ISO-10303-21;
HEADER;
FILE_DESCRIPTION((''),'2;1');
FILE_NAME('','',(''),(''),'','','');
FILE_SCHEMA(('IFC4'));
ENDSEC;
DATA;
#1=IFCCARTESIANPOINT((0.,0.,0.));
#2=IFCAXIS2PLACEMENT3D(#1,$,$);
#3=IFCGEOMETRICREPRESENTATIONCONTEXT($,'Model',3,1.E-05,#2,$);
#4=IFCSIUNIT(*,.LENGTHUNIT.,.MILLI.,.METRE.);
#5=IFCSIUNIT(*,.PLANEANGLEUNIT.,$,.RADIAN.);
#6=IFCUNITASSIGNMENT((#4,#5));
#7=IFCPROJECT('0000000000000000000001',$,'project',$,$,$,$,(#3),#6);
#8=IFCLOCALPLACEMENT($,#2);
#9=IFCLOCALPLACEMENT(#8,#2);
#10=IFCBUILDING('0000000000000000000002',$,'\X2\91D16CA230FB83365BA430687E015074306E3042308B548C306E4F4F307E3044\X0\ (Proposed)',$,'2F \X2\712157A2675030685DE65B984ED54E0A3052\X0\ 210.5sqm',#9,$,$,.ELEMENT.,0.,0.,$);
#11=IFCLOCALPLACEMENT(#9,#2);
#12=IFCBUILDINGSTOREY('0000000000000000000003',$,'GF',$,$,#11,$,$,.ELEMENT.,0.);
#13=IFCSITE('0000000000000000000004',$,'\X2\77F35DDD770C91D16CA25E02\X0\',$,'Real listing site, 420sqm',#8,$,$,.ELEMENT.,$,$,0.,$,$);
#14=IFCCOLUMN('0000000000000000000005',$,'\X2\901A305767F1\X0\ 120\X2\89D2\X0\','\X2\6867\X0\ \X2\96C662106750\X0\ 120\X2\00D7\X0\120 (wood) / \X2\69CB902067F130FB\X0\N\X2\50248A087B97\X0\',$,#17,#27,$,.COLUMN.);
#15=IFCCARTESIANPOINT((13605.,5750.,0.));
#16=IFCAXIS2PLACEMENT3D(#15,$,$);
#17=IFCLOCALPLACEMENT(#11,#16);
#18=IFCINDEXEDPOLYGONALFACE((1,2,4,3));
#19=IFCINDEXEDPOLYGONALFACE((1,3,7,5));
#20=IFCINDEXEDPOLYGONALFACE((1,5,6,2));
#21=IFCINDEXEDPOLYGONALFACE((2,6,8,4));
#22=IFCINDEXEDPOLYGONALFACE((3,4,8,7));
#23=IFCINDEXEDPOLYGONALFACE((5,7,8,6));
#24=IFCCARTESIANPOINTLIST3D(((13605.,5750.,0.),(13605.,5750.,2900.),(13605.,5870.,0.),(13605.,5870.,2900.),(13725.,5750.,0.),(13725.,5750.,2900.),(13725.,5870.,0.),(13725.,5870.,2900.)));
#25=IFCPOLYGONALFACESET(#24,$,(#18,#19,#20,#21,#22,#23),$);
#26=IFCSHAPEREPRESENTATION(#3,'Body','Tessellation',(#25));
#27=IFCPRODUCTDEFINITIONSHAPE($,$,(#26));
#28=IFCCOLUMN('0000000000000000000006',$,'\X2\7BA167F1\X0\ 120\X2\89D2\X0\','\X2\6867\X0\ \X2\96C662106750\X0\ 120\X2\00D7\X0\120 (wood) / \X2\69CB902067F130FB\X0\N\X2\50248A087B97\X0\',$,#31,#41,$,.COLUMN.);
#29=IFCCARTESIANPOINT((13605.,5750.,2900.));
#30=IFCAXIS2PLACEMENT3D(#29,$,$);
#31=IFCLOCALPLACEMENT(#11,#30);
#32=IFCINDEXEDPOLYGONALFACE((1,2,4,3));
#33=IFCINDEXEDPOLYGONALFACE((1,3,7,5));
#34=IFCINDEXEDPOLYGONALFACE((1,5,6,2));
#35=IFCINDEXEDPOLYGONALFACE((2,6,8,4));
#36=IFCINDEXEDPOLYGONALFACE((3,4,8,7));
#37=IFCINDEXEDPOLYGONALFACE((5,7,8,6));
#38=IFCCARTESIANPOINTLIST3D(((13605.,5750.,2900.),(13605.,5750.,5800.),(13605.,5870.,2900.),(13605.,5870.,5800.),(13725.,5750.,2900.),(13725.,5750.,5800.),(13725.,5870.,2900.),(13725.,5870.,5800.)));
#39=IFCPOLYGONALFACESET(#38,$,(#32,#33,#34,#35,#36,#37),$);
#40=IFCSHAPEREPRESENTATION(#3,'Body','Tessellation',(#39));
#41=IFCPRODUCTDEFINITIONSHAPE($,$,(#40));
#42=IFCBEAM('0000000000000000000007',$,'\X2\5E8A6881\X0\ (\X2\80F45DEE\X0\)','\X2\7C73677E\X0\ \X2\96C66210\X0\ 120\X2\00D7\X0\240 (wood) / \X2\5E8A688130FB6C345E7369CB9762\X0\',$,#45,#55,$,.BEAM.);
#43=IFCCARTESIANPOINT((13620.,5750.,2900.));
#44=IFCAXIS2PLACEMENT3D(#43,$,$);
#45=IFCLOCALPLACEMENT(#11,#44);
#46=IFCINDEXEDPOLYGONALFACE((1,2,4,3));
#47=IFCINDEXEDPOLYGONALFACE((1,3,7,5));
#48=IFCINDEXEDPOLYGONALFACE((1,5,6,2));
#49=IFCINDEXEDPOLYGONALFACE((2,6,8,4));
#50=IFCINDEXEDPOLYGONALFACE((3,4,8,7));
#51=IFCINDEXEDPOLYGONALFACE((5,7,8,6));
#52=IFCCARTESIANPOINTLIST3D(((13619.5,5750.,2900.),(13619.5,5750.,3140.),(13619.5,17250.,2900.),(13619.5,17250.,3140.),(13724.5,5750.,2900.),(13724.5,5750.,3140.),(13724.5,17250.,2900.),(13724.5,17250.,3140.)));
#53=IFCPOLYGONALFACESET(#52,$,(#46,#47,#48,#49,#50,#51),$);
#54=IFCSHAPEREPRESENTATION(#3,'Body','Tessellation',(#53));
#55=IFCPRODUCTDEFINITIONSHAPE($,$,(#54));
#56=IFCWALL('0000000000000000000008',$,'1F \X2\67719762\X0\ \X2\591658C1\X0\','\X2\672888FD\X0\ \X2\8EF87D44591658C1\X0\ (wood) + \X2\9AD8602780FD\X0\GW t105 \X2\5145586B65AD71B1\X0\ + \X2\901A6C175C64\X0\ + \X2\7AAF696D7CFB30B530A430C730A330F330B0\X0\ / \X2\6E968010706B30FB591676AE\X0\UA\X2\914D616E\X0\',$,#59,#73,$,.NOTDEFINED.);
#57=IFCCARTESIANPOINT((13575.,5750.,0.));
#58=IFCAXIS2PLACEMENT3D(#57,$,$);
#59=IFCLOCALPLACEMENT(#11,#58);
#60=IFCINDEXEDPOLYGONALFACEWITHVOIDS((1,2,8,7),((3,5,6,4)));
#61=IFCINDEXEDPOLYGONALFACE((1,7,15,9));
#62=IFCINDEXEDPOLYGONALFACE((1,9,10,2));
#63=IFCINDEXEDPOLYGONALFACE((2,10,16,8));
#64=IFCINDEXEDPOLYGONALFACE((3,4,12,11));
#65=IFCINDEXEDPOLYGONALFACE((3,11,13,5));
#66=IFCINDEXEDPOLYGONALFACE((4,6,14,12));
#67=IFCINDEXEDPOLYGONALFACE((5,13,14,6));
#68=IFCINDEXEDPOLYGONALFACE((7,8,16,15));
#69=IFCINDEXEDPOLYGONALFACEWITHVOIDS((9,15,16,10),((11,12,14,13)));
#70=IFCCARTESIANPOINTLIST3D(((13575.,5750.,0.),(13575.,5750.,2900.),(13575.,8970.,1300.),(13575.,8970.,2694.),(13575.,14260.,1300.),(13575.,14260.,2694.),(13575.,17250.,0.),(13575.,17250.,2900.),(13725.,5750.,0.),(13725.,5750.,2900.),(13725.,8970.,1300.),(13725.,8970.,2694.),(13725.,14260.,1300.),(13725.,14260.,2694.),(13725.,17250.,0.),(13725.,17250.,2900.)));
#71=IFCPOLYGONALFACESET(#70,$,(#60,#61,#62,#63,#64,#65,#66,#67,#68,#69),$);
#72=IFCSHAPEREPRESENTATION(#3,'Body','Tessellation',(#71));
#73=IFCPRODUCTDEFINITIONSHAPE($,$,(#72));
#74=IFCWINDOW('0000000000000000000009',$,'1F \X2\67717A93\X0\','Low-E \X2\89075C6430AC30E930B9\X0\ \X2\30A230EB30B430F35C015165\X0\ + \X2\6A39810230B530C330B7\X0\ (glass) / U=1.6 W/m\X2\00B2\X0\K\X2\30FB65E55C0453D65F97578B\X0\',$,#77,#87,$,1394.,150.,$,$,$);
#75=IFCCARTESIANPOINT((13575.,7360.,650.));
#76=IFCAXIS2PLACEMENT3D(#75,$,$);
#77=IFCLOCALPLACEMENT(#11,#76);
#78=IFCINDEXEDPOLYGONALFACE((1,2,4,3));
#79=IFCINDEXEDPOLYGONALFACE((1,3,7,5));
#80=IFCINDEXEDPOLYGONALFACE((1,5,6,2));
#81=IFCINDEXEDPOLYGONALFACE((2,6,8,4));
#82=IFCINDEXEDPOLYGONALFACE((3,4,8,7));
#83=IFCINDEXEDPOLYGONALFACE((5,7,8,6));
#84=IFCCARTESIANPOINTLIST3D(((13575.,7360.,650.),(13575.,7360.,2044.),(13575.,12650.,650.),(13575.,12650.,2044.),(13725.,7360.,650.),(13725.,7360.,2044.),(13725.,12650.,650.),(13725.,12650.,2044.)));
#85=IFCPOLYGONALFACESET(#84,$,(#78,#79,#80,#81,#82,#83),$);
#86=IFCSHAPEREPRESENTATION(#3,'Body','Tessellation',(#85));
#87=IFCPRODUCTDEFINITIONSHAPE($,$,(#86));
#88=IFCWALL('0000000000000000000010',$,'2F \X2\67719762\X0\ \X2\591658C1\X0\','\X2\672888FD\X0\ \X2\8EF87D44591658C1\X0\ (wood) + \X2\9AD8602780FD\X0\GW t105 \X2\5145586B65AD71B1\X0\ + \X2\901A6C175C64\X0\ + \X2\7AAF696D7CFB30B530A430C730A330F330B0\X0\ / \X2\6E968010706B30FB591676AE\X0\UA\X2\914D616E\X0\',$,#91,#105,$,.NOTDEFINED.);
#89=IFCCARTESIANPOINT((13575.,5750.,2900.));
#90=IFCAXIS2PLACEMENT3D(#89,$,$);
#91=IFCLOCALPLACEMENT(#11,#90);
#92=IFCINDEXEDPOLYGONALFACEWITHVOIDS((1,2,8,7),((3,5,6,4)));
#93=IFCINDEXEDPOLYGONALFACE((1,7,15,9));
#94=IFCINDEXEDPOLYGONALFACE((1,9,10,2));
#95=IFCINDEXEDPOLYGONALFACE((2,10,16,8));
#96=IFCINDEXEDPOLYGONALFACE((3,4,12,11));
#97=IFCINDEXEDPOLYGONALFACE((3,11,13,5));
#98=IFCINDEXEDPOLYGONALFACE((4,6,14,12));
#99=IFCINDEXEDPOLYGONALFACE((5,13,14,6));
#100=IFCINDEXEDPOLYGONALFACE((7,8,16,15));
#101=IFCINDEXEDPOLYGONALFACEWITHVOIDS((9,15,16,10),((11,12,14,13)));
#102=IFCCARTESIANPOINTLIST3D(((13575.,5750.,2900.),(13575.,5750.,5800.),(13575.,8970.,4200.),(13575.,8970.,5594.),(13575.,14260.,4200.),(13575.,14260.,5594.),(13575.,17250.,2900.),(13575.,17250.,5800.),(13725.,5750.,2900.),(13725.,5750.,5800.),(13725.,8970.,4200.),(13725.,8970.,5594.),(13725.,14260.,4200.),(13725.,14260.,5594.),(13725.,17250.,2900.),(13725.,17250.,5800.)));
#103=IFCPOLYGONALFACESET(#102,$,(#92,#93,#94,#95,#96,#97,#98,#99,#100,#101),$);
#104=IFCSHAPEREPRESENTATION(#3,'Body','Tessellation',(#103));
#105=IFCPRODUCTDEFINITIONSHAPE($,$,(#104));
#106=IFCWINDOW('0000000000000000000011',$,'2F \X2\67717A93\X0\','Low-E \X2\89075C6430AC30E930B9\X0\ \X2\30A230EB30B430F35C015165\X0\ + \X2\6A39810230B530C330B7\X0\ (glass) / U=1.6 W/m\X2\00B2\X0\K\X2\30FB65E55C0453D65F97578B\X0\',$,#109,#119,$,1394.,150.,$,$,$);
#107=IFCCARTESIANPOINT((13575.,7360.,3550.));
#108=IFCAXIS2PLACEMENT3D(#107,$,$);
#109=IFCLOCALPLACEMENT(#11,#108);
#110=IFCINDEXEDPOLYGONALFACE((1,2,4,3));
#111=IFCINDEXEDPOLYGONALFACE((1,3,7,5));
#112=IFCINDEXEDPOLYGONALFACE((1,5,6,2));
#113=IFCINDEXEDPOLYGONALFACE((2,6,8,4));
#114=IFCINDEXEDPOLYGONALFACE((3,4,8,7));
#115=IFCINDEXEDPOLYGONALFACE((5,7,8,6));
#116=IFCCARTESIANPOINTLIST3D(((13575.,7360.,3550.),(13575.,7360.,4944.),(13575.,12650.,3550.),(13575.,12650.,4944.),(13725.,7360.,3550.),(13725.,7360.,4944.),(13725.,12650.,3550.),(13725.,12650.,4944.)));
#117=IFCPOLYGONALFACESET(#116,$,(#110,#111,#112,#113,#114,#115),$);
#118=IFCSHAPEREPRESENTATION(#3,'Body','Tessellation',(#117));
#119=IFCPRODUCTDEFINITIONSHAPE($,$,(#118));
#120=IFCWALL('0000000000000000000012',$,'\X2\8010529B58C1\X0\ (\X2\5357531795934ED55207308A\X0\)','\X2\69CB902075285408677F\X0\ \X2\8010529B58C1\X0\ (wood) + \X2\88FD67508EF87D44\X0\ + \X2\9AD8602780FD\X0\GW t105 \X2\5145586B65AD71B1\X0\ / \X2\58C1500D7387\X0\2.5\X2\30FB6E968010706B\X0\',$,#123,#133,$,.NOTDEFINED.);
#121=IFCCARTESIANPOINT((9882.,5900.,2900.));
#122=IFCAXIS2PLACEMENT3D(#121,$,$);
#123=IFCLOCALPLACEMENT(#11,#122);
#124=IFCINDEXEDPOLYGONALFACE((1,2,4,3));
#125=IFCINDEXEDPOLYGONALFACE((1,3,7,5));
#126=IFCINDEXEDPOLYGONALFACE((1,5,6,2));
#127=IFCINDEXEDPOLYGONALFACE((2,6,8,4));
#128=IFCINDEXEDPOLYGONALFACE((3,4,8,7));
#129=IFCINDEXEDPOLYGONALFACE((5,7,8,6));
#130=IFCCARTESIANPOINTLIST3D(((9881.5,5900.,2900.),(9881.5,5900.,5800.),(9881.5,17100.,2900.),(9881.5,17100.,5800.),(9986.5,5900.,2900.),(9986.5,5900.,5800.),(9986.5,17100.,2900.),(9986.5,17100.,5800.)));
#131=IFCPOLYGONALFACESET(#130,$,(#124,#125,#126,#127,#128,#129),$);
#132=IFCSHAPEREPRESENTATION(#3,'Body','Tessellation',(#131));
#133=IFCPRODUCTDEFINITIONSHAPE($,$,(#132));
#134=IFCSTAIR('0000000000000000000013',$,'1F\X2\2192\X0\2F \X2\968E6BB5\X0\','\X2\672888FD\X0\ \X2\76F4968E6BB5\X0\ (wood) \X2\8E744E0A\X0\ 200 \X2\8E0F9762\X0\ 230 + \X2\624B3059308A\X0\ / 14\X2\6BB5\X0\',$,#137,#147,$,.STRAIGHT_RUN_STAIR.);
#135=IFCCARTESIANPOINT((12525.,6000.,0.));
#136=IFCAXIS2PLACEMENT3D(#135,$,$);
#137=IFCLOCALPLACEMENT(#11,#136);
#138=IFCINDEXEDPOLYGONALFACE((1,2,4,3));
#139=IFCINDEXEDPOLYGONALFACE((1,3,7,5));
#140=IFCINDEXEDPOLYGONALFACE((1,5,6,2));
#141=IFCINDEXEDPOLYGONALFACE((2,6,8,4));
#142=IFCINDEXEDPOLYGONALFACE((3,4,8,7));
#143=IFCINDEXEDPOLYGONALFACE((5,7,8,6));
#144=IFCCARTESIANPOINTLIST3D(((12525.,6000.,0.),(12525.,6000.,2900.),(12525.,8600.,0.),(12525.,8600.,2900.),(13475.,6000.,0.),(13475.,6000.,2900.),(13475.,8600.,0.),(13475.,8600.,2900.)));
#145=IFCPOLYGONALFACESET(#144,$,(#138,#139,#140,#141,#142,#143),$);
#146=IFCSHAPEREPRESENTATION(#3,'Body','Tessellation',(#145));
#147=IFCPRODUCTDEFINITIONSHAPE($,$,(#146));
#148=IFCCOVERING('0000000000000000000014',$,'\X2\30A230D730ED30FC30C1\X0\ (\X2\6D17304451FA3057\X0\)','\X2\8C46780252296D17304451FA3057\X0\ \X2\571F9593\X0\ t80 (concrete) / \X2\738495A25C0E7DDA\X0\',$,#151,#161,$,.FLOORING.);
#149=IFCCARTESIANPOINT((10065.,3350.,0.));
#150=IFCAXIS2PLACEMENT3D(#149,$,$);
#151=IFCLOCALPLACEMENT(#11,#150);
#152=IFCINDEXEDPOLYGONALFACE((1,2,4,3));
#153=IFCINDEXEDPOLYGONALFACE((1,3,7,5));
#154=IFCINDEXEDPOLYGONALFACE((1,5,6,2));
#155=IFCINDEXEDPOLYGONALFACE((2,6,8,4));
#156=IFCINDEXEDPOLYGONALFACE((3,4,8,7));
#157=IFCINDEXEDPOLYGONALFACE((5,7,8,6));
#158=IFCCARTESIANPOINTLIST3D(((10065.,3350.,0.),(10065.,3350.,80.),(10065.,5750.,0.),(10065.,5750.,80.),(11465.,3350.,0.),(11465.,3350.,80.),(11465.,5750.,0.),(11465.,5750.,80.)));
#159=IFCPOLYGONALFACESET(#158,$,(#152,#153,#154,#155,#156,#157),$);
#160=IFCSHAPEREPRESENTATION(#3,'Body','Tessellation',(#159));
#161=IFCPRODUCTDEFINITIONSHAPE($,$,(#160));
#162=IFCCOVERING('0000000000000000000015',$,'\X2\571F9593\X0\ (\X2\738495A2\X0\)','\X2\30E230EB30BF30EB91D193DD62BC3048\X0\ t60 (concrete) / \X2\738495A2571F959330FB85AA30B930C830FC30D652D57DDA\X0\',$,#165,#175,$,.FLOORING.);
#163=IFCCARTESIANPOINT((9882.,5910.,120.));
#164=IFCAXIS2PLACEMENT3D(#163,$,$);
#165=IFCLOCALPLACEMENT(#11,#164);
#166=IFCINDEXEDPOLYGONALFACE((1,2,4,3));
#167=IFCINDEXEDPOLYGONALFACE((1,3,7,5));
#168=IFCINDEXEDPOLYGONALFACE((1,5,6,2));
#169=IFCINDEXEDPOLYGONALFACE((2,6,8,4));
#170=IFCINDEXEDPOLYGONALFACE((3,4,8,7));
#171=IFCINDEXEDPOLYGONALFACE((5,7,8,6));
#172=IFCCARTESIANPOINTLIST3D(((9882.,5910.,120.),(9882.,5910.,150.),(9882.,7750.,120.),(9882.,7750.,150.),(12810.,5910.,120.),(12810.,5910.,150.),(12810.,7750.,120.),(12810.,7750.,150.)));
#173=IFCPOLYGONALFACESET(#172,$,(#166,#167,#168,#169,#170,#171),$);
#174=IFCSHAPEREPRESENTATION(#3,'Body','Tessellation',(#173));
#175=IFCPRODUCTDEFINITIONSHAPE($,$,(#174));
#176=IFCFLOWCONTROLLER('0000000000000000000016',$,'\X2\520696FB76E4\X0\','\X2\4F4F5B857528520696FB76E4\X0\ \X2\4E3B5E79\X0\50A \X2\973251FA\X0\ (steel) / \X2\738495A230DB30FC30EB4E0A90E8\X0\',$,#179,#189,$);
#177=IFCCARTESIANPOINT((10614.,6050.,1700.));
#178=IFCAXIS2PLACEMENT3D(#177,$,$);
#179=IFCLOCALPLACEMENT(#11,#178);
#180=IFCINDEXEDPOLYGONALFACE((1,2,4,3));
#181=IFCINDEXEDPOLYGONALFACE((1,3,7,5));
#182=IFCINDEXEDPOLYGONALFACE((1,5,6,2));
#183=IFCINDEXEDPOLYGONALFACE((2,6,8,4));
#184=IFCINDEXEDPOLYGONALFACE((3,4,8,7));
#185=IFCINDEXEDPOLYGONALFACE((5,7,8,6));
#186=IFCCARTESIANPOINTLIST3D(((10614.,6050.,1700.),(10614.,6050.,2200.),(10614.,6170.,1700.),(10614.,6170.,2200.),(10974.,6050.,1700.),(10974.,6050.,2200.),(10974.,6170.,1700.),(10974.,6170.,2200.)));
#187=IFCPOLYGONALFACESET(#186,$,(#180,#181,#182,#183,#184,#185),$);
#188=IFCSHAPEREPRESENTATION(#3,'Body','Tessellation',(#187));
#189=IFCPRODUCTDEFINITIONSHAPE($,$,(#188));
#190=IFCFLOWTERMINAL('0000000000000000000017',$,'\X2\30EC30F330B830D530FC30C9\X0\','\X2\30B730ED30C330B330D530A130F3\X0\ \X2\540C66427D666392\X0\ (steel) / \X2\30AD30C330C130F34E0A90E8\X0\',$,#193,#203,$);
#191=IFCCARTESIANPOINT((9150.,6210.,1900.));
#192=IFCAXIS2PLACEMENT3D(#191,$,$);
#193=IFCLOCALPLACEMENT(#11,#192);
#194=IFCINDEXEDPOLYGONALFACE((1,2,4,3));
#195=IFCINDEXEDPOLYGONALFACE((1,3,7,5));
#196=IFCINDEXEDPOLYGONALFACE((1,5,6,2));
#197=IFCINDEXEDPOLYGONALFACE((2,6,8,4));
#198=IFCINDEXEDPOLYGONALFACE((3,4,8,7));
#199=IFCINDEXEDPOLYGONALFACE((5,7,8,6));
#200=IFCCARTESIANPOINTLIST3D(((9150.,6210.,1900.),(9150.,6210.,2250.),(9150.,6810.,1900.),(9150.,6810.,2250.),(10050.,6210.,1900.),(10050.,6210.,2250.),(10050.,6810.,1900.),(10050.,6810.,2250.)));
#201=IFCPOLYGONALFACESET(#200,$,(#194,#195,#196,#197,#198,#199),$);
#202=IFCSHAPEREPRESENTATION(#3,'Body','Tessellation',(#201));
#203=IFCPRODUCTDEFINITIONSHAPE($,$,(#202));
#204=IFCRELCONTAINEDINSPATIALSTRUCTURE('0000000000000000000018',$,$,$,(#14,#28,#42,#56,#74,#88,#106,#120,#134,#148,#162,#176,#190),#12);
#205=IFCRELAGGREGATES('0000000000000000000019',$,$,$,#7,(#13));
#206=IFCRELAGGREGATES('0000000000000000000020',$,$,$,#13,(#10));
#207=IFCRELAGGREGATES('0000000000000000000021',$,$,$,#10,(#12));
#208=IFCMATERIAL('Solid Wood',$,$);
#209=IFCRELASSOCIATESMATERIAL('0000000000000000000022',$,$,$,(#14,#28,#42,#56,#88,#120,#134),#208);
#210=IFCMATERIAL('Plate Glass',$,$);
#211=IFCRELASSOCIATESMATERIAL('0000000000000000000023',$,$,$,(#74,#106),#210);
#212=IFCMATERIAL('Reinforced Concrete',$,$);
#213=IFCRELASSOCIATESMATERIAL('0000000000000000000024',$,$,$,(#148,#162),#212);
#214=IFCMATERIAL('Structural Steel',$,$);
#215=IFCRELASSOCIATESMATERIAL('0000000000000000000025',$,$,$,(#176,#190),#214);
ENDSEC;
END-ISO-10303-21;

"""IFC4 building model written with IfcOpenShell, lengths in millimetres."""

from ifc_helpers import new_model, si_unit, frame, frame_2d, origin, place, context, project, spatial, rectangle, extrude, material, element, fill, save


model = new_model("IFC4")

# Units and contexts
model_context = context("Model", 3, precision=1e-05, world=origin())
ifc_project = project(units=[si_unit("LENGTHUNIT", "METRE", prefix="MILLI"), si_unit("PLANEANGLEUNIT", "RADIAN")], contexts=[model_context])

# Site, building, storey
site_placement = place(None, origin())
site = spatial("IfcSite", under=ifc_project, at=site_placement, Name="石川県金沢市", ObjectType="Real listing site, 420sqm", CompositionType="ELEMENT", RefElevation=0.0)
building_placement = place(site_placement, origin())
building = spatial("IfcBuilding", under=site, at=building_placement, Name="金沢・茶室と縁側のある和の住まい (Proposed)", ObjectType="2F 無垢材と左官仕上げ 210.5sqm", CompositionType="ELEMENT", ElevationOfRefHeight=0.0, ElevationOfTerrain=0.0)
storey_placement = place(building_placement, origin())
storey = spatial("IfcBuildingStorey", under=building, at=storey_placement, Name="GF", CompositionType="ELEMENT", Elevation=0.0)

# Columns
ifc_material_1 = material(Name="Solid Wood")
column_1_placement = place(storey_placement, frame((13605.0, 5750.0, 0.0)))
element("IfcColumn", 1, at=column_1_placement, inside=storey, material=ifc_material_1, Name="通し柱 120角", Description="桧 集成材 120×120 (wood) / 構造柱・N値計算", PredefinedType="COLUMN", context=model_context, shape_type="SweptSolid", body=[
    extrude(rectangle(XDim=120.0, YDim=120.0, at=frame_2d((60.0, 60.0))), frame((13605.0, 5750.0, 0.0)), (0.0, 0.0, 1.0), 2900.0),
])
column_2_placement = place(storey_placement, frame((13605.0, 5750.0, 2900.0)))
element("IfcColumn", 2, at=column_2_placement, inside=storey, material=ifc_material_1, Name="管柱 120角", Description="桧 集成材 120×120 (wood) / 構造柱・N値計算", PredefinedType="COLUMN", context=model_context, shape_type="SweptSolid", body=[
    extrude(rectangle(XDim=120.0, YDim=120.0, at=frame_2d((60.0, 60.0))), frame((13605.0, 5750.0, 2900.0)), (0.0, 0.0, 1.0), 2900.0),
])

# Beam
beam_1_placement = place(storey_placement, frame((13620.0, 5750.0, 2900.0)))
element("IfcBeam", 3, at=beam_1_placement, inside=storey, material=ifc_material_1, Name="床梁 (胴差)", Description="米松 集成 120×240 (wood) / 床梁・水平構面", PredefinedType="BEAM", context=model_context, shape_type="SweptSolid", body=[
    extrude(rectangle(XDim=105.0, YDim=11500.0, at=frame_2d((52.0, 5750.0))), frame((13620.0, 5750.0, 2900.0)), (0.0, 0.0, 1.0), 240.0),
])

# Wall, opening, window
wall_1_placement = place(storey_placement, frame((13575.0, 5750.0, 0.0)))
wall_1 = element("IfcWall", 4, at=wall_1_placement, inside=storey, material=ifc_material_1, Name="1F 東面 外壁", Description="木製 軸組外壁 (wood) + 高性能GW t105 充填断熱 + 通気層 + 窯業系サイディング / 準耐火・外皮UA配慮", PredefinedType="NOTDEFINED", context=model_context, shape_type="SweptSolid", body=[
    extrude(rectangle(XDim=150.0, YDim=11500.0, at=frame_2d((75.0, 5750.0))), frame((13575.0, 5750.0, 0.0)), (0.0, 0.0, 1.0), 2900.0),
])
opening_1_placement = place(storey_placement, frame((13575.0, 7360.0, 650.0)))
opening_1 = element("IfcOpeningElement", 5, at=opening_1_placement, cuts=wall_1, PredefinedType="NOTDEFINED", context=model_context, shape_type="SweptSolid", body=[
    extrude(rectangle(XDim=150.0, YDim=5290.0, at=frame_2d((75.0, 2645.0))), frame((13575.0, 7360.0, 650.0)), (0.0, 0.0, 1.0), 1394.0),
])
ifc_material_2 = material(Name="Plate Glass")
window_1_placement = place(storey_placement, frame((13575.0, 7360.0, 650.0)))
window_1 = element("IfcWindow", 6, at=window_1_placement, inside=storey, material=ifc_material_2, Name="1F 東窓", Description="Low-E 複層ガラス アルゴン封入 + 樹脂サッシ (glass) / U=1.6 W/m²K・日射取得型", OverallHeight=1394.0, OverallWidth=150.0, context=model_context, shape_type="SweptSolid", body=[
    extrude(rectangle(XDim=150.0, YDim=5290.0, at=frame_2d((75.0, 2645.0))), frame((13575.0, 7360.0, 650.0)), (0.0, 0.0, 1.0), 1394.0),
])
fill(opening_1, window_1)

# Wall, opening, window
wall_2_placement = place(storey_placement, frame((13575.0, 5750.0, 2900.0)))
wall_2 = element("IfcWall", 7, at=wall_2_placement, inside=storey, material=ifc_material_1, Name="2F 東面 外壁", Description="木製 軸組外壁 (wood) + 高性能GW t105 充填断熱 + 通気層 + 窯業系サイディング / 準耐火・外皮UA配慮", PredefinedType="NOTDEFINED", context=model_context, shape_type="SweptSolid", body=[
    extrude(rectangle(XDim=150.0, YDim=11500.0, at=frame_2d((75.0, 5750.0))), frame((13575.0, 5750.0, 2900.0)), (0.0, 0.0, 1.0), 2900.0),
])
opening_2_placement = place(storey_placement, frame((13575.0, 7360.0, 3550.0)))
opening_2 = element("IfcOpeningElement", 8, at=opening_2_placement, cuts=wall_2, PredefinedType="NOTDEFINED", context=model_context, shape_type="SweptSolid", body=[
    extrude(rectangle(XDim=150.0, YDim=5290.0, at=frame_2d((75.0, 2645.0))), frame((13575.0, 7360.0, 3550.0)), (0.0, 0.0, 1.0), 1394.0),
])
window_2_placement = place(storey_placement, frame((13575.0, 7360.0, 3550.0)))
window_2 = element("IfcWindow", 9, at=window_2_placement, inside=storey, material=ifc_material_2, Name="2F 東窓", Description="Low-E 複層ガラス アルゴン封入 + 樹脂サッシ (glass) / U=1.6 W/m²K・日射取得型", OverallHeight=1394.0, OverallWidth=150.0, context=model_context, shape_type="SweptSolid", body=[
    extrude(rectangle(XDim=150.0, YDim=5290.0, at=frame_2d((75.0, 2645.0))), frame((13575.0, 7360.0, 3550.0)), (0.0, 0.0, 1.0), 1394.0),
])
fill(opening_2, window_2)

# Wall
wall_3_placement = place(storey_placement, frame((9882.0, 5900.0, 2900.0)))
element("IfcWall", 10, at=wall_3_placement, inside=storey, material=ifc_material_1, Name="耐力壁 (南北間仕切り)", Description="構造用合板 耐力壁 (wood) + 製材軸組 + 高性能GW t105 充填断熱 / 壁倍率2.5・準耐火", PredefinedType="NOTDEFINED", context=model_context, shape_type="SweptSolid", body=[
    extrude(rectangle(XDim=105.0, YDim=11200.0, at=frame_2d((52.0, 5600.0))), frame((9882.0, 5900.0, 2900.0)), (0.0, 0.0, 1.0), 2900.0),
])

# Stair
stair_placement = place(storey_placement, frame((12525.0, 6000.0, 0.0)))
element("IfcStair", 11, at=stair_placement, inside=storey, material=ifc_material_1, Name="1F→2F 階段", Description="木製 直階段 (wood) 蹴上 200 踏面 230 + 手すり / 14段", PredefinedType="STRAIGHT_RUN_STAIR", context=model_context, shape_type="SweptSolid", body=[
    extrude(rectangle(XDim=950.0, YDim=2600.0, at=frame_2d((475.0, 1300.0))), frame((12525.0, 6000.0, 0.0)), (0.0, 0.0, 1.0), 2900.0),
])

# Coverings
ifc_material_3 = material(Name="Reinforced Concrete")
covering_1_placement = place(storey_placement, frame((10065.0, 3350.0, 0.0)))
element("IfcCovering", 12, at=covering_1_placement, inside=storey, material=ifc_material_3, Name="アプローチ (洗い出し)", Description="豆砂利洗い出し 土間 t80 (concrete) / 玄関導線", PredefinedType="FLOORING", context=model_context, shape_type="SweptSolid", body=[
    extrude(rectangle(XDim=1400.0, YDim=2400.0, at=frame_2d((700.0, 1200.0))), frame((10065.0, 3350.0, 0.0)), (0.0, 0.0, 1.0), 80.0),
])
covering_2_placement = place(storey_placement, frame((9882.0, 5910.0, 120.0)))
element("IfcCovering", 13, at=covering_2_placement, inside=storey, material=ifc_material_3, Name="土間 (玄関)", Description="モルタル金鏝押え t60 (concrete) / 玄関土間・薪ストーブ動線", PredefinedType="FLOORING", context=model_context, shape_type="SweptSolid", body=[
    extrude(rectangle(XDim=2928.0, YDim=1840.0, at=frame_2d((1464.0, 920.0))), frame((9882.0, 5910.0, 120.0)), (0.0, 0.0, 1.0), 30.0),
])

# Flow controller
ifc_material_4 = material(Name="Structural Steel")
flow_controller_placement = place(storey_placement, frame((10614.0, 6050.0, 1700.0)))
element("IfcFlowController", 14, at=flow_controller_placement, inside=storey, material=ifc_material_4, Name="分電盤", Description="住宅用分電盤 主幹50A 露出 (steel) / 玄関ホール上部", context=model_context, shape_type="SweptSolid", body=[
    extrude(rectangle(XDim=360.0, YDim=120.0, at=frame_2d((180.0, 60.0))), frame((10614.0, 6050.0, 1700.0)), (0.0, 0.0, 1.0), 500.0),
])

# Flow terminal
flow_terminal_1_placement = place(storey_placement, frame((9150.0, 6210.0, 1900.0)))
element("IfcFlowTerminal", 15, at=flow_terminal_1_placement, inside=storey, material=ifc_material_4, Name="レンジフード", Description="シロッコファン 同時給排 (steel) / キッチン上部", context=model_context, shape_type="SweptSolid", body=[
    extrude(rectangle(XDim=900.0, YDim=600.0, at=frame_2d((450.0, 300.0))), frame((9150.0, 6210.0, 1900.0)), (0.0, 0.0, 1.0), 350.0),
])

save(model, "model.ifc")
